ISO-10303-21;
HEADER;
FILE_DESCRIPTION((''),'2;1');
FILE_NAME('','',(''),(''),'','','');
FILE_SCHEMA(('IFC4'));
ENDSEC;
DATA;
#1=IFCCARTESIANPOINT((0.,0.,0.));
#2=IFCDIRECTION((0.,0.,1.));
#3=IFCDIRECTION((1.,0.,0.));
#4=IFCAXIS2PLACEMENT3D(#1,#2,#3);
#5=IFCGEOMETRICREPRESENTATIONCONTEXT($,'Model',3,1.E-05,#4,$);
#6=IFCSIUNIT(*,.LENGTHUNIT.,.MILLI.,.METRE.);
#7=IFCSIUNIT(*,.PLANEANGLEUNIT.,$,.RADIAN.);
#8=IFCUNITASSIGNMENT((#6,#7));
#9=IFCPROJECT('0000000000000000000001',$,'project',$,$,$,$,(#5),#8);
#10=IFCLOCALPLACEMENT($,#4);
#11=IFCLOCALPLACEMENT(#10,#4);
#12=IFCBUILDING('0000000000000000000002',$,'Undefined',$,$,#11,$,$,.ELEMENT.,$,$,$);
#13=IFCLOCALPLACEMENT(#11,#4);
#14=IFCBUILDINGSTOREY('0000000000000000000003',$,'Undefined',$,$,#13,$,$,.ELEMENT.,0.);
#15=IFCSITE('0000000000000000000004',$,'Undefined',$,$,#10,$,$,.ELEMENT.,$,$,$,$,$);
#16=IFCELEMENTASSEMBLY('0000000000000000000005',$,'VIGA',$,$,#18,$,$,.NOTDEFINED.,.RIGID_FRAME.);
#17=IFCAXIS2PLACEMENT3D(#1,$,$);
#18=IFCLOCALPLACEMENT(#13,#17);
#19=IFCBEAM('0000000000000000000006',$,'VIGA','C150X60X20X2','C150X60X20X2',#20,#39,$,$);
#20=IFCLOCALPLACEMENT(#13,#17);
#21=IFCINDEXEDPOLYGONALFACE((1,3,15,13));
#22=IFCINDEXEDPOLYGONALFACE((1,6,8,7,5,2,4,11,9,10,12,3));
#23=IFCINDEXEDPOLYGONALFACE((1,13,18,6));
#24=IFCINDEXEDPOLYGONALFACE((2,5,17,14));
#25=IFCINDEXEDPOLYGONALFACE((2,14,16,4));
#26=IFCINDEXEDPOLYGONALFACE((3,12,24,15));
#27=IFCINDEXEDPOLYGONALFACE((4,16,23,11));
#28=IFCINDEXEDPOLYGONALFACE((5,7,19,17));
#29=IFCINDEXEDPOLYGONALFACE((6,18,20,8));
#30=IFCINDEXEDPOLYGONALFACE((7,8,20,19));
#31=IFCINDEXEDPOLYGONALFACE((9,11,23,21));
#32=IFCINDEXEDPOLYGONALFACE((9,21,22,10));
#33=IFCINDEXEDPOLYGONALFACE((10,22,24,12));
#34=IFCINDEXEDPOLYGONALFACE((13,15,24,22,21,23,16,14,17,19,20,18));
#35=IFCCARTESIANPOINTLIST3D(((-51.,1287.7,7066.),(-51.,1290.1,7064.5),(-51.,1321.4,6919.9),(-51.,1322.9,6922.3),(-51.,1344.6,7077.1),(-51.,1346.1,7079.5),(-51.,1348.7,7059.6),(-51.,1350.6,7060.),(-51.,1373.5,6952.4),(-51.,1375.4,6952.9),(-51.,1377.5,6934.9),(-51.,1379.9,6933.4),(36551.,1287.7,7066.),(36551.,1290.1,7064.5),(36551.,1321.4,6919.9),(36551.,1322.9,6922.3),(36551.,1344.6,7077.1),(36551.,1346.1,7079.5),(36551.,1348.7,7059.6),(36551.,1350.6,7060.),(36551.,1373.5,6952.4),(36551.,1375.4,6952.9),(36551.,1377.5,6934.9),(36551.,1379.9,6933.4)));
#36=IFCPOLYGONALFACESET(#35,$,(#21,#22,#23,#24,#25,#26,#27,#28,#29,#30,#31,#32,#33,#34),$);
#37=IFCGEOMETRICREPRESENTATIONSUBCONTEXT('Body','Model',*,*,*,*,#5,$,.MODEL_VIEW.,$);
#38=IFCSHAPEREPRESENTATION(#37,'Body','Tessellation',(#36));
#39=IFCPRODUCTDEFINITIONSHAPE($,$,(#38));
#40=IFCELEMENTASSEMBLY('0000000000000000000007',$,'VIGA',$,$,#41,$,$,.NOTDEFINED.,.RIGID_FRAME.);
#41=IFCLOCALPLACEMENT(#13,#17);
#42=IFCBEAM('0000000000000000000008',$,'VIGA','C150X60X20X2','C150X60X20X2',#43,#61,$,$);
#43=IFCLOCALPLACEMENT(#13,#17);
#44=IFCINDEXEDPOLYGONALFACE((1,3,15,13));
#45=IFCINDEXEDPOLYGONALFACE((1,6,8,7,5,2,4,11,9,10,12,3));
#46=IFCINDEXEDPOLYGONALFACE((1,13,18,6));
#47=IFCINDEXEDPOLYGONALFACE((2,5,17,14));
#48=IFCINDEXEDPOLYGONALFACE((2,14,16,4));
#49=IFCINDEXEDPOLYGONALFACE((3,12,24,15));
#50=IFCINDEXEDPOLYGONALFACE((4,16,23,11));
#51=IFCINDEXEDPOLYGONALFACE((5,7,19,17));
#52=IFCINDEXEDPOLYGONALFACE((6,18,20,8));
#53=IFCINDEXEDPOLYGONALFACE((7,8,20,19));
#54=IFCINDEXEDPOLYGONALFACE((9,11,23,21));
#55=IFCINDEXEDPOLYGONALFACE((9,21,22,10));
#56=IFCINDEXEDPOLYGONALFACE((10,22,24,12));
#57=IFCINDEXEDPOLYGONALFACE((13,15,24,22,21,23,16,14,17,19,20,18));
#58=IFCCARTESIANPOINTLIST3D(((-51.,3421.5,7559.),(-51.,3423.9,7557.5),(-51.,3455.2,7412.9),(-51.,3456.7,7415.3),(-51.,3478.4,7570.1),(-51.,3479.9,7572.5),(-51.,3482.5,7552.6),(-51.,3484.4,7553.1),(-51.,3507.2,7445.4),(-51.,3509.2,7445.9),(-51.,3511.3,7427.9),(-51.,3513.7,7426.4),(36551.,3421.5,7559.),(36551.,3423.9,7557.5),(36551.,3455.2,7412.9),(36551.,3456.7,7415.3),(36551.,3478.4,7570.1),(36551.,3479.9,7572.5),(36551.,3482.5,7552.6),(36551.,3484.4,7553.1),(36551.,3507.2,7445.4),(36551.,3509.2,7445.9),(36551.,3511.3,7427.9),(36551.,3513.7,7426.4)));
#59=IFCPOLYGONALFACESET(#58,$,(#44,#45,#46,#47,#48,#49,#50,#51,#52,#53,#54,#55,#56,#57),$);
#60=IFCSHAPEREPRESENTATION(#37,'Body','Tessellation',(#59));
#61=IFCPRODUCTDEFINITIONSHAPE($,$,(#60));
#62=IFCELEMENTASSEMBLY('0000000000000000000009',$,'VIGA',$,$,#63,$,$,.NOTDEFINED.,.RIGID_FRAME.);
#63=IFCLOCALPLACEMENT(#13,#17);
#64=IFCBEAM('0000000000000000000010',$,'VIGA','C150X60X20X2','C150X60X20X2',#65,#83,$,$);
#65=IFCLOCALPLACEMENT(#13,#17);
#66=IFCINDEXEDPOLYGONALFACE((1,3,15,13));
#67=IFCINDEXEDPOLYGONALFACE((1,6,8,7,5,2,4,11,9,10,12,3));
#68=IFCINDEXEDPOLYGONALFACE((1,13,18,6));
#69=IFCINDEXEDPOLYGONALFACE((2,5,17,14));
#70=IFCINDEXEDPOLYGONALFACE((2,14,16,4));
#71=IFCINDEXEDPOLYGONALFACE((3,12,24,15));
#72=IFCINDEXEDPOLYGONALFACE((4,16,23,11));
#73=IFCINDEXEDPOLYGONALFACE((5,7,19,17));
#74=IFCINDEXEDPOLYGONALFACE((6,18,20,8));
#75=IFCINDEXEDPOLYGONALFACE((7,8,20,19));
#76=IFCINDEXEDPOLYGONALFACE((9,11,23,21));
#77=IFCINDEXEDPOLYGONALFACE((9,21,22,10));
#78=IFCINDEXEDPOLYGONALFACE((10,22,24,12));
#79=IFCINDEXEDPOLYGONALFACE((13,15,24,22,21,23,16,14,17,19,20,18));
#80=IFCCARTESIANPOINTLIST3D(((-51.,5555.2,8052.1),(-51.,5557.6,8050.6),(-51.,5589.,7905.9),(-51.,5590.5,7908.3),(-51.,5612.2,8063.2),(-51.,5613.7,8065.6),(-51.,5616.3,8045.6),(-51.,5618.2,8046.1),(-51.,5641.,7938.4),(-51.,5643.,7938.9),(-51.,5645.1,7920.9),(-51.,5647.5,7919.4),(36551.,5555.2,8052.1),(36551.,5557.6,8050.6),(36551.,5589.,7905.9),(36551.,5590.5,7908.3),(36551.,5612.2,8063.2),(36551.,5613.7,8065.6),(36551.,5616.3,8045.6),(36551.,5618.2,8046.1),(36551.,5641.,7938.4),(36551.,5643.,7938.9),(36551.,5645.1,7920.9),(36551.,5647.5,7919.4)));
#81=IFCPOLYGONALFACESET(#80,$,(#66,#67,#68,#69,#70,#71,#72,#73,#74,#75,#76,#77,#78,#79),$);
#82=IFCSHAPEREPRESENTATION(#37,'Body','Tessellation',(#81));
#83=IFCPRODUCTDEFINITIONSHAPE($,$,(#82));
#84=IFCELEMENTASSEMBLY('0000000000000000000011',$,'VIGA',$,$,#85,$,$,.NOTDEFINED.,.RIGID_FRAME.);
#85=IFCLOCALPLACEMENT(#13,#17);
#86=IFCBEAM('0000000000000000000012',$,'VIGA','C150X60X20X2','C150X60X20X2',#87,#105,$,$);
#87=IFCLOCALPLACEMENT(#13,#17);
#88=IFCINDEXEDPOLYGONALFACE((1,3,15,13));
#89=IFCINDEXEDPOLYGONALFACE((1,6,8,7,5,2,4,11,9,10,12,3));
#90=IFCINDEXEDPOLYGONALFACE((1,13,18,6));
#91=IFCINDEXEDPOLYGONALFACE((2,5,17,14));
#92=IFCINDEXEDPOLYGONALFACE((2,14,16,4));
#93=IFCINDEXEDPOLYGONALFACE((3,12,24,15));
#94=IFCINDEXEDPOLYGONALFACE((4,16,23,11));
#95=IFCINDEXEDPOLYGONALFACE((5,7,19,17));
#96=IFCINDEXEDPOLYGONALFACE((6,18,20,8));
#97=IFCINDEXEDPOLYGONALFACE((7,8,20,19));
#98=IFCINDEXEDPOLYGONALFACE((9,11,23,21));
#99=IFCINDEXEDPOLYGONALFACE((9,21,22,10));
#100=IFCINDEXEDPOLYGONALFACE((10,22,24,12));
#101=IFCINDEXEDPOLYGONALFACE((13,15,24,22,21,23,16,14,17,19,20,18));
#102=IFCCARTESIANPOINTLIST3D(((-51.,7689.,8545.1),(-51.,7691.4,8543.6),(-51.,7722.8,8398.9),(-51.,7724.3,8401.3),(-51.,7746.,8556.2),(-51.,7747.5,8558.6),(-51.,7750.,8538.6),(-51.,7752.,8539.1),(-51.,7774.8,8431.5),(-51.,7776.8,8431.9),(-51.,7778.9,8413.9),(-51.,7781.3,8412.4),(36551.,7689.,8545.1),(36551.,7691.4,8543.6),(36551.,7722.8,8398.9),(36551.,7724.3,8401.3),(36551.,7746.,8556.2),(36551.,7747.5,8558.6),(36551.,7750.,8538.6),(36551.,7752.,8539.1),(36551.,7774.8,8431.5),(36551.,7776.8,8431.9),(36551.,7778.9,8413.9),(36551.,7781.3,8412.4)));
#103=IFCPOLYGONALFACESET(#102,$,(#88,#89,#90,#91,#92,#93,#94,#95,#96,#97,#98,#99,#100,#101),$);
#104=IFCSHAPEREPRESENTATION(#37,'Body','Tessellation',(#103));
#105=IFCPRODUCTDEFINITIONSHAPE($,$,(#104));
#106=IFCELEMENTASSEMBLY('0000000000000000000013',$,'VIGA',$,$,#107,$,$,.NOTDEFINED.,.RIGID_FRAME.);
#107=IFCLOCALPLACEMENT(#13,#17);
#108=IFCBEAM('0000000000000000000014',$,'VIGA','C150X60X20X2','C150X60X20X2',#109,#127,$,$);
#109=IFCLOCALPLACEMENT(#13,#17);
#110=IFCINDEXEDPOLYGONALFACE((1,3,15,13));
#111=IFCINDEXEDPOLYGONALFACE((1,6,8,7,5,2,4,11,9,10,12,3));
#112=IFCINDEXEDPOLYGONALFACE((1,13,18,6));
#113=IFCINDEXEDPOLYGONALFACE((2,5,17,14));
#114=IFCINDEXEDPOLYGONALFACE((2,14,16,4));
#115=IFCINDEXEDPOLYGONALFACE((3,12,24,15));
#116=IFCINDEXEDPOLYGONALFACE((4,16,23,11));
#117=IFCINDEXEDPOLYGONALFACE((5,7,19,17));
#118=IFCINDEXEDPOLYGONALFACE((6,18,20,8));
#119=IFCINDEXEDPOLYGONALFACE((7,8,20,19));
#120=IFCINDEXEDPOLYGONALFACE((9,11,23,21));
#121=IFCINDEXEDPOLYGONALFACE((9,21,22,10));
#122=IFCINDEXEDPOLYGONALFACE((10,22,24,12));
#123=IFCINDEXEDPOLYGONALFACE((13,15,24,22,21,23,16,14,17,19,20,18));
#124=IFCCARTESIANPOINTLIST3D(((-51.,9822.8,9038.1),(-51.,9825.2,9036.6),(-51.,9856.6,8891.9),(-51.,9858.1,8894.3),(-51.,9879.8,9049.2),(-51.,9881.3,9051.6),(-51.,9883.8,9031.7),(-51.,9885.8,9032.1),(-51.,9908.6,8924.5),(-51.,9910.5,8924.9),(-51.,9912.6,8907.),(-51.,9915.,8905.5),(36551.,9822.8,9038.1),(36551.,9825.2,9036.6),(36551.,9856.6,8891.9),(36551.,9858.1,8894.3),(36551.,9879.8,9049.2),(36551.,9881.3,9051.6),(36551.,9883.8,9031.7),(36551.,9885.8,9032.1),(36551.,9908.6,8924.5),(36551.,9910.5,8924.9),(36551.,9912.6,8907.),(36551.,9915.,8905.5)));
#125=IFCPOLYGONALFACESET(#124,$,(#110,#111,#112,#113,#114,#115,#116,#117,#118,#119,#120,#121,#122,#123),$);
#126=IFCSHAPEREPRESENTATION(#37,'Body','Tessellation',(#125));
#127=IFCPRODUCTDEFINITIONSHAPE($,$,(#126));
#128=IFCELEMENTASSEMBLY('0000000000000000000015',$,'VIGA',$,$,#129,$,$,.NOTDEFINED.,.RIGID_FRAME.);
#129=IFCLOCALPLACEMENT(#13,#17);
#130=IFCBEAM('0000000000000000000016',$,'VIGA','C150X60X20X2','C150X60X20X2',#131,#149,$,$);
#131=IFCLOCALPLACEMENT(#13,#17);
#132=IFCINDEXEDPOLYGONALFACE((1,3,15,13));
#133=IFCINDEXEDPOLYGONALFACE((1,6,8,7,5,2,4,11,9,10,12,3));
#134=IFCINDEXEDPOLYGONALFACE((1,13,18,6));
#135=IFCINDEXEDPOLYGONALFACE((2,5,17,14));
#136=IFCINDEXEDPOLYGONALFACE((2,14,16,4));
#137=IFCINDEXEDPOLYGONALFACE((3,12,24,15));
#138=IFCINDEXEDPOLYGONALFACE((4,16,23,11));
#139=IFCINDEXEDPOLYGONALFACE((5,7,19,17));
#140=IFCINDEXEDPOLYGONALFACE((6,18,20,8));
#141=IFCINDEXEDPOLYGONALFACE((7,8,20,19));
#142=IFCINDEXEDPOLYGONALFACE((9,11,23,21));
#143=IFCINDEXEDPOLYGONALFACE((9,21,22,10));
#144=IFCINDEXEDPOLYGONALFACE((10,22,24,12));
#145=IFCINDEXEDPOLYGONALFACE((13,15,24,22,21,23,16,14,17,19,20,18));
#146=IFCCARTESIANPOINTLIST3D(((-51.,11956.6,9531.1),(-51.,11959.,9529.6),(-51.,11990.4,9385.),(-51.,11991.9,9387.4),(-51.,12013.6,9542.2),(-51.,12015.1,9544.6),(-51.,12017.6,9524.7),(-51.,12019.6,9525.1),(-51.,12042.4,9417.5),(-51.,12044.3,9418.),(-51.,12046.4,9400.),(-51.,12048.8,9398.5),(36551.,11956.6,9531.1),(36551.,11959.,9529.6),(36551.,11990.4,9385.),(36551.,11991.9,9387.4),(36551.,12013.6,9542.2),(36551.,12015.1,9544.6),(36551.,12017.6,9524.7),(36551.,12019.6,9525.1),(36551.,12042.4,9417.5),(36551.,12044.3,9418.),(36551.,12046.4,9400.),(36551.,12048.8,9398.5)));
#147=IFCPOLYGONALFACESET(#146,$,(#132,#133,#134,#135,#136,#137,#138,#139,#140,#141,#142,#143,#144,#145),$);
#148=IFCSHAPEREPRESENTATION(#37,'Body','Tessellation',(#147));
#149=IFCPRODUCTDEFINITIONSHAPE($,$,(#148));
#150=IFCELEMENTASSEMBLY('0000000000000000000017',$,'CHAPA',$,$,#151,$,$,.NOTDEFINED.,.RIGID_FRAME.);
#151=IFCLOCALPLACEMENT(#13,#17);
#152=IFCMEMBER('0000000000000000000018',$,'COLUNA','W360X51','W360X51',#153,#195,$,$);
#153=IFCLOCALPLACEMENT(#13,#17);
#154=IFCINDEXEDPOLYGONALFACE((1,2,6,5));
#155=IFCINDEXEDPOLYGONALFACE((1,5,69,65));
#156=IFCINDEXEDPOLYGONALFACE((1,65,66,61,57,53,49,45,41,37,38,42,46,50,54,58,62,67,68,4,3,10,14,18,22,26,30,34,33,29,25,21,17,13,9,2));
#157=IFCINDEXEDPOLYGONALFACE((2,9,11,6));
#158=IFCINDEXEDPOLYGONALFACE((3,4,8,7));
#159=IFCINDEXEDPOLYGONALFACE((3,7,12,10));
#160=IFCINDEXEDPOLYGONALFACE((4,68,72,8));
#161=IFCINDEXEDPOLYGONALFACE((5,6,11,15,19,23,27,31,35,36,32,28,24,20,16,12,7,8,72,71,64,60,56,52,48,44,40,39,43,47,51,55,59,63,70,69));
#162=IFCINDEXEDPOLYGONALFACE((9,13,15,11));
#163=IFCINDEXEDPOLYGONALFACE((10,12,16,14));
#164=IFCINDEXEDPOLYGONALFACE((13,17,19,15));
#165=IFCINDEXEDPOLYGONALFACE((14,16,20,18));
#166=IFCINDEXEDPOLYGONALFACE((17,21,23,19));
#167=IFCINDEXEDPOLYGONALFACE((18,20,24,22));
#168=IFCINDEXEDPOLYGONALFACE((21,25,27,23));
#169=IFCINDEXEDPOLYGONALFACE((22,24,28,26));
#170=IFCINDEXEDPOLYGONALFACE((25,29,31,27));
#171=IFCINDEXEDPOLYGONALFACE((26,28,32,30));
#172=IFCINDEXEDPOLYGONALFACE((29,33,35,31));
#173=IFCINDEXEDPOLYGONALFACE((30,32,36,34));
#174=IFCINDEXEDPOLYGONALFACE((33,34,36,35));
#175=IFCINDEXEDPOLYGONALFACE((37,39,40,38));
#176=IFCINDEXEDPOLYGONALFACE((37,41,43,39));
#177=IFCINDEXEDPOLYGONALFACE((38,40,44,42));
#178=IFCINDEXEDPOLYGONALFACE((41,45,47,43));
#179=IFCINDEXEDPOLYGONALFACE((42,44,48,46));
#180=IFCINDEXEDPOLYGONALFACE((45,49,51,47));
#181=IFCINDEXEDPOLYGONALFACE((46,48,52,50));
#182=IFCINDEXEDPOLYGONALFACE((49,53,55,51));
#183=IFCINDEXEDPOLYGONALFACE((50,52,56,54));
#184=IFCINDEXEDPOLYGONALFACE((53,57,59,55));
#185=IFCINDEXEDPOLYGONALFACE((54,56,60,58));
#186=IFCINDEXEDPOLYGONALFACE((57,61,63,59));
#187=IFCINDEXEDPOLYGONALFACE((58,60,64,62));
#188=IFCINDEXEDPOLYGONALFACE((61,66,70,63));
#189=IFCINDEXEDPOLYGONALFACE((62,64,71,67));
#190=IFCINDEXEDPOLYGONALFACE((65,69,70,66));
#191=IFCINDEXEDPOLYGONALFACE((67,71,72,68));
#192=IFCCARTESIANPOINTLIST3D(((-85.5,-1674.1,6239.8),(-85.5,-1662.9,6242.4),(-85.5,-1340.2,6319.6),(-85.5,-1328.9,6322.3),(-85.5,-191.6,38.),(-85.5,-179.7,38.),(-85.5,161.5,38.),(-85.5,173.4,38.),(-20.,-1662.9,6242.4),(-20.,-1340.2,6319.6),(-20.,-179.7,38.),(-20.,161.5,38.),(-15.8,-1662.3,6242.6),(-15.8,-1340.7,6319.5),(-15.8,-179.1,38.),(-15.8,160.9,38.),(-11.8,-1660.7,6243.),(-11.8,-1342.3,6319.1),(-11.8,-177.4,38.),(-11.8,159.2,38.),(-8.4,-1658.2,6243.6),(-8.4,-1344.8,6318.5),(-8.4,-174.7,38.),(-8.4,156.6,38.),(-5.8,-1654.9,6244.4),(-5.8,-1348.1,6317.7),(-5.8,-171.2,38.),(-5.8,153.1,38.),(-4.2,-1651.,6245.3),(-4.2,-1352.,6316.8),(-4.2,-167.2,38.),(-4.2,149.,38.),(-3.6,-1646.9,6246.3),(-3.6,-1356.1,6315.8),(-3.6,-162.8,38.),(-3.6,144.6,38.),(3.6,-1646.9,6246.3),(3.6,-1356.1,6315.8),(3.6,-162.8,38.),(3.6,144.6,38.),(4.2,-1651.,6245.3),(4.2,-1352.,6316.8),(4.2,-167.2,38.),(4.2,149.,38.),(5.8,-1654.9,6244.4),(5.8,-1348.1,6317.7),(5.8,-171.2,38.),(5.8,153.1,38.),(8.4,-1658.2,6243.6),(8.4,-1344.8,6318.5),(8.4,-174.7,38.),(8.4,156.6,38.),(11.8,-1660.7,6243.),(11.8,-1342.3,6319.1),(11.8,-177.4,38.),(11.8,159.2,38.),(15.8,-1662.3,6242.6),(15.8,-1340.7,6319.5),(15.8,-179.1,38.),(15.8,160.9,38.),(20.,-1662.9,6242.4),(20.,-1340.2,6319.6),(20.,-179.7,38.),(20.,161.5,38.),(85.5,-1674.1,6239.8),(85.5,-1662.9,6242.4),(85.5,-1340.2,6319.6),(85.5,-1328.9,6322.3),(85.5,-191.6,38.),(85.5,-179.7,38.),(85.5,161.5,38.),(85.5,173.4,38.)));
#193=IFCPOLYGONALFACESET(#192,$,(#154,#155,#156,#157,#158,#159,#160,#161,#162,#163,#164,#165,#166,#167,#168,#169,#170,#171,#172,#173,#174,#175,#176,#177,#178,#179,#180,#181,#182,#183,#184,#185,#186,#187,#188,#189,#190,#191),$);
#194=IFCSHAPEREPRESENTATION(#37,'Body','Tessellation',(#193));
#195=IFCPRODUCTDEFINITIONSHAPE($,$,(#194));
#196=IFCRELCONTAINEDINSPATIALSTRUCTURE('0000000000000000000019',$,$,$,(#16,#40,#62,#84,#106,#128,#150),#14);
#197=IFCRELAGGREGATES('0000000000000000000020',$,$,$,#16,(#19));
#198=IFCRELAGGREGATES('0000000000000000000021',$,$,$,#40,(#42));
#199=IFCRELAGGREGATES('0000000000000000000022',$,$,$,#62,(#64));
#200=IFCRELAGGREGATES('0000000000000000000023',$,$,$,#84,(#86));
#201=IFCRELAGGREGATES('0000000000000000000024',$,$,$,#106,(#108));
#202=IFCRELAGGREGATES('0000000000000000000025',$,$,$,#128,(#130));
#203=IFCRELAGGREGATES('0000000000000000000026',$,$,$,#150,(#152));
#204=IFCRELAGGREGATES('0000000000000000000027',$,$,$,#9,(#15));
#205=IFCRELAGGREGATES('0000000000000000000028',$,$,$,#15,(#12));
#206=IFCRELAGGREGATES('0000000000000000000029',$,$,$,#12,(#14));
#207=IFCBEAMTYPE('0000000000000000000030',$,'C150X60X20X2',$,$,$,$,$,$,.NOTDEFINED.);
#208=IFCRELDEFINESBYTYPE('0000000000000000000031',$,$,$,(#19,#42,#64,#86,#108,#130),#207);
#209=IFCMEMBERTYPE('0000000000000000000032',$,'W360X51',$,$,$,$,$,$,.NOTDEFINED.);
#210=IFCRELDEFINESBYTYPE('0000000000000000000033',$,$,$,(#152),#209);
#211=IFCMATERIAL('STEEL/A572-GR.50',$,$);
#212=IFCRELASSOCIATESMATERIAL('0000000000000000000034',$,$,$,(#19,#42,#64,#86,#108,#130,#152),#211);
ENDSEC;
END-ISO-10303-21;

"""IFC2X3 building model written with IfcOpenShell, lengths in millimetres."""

from ifc_helpers import new_model, si_unit, frame, origin_with_axes, origin_2d_with_axis, place, context, subcontext, project, spatial, i_section, c_section, extrude, clip, halfspace, material, type_object, element, aggregate, save


model = new_model("IFC2X3")

# Units and contexts
model_context = context("Model", 3, precision=1e-05, world=origin_with_axes())
body_context = subcontext(model_context, "Body", "Model", "MODEL_VIEW")
ifc_project = project(units=[si_unit("LENGTHUNIT", "METRE", prefix="MILLI"), si_unit("PLANEANGLEUNIT", "RADIAN")], contexts=[model_context])

# Site, building, storey
site_placement = place(None, origin_with_axes())
site = spatial("IfcSite", under=ifc_project, at=site_placement, Name="Undefined", CompositionType="ELEMENT")
building_placement = place(site_placement, origin_with_axes())
building = spatial("IfcBuilding", under=site, at=building_placement, Name="Undefined", CompositionType="ELEMENT")
storey_placement = place(building_placement, origin_with_axes())
storey = spatial("IfcBuildingStorey", under=building, at=storey_placement, Name="Undefined", CompositionType="ELEMENT", Elevation=0.0)

# Element assemblies, beams
assembly_1_placement = place(storey_placement, origin_with_axes())
assembly_1 = element("IfcElementAssembly", 1, at=assembly_1_placement, inside=storey, Name="VIGA", AssemblyPlace="NOTDEFINED", PredefinedType="RIGID_FRAME")
ifc_material_1 = material(Name="STEEL/A572-GR.50")
beam_type = type_object("IfcBeamType", Name="C150X60X20X2", PredefinedType="NOTDEFINED")
beam_1_placement = place(assembly_1_placement, frame((-51.0, 1333.8, 6999.7), z_axis=(0.0, 0.225124, -0.97433), x_axis=(1.0, 0.0, 0.0)))
beam_1 = element("IfcBeam", 2, at=beam_1_placement, type_object=beam_type, material=ifc_material_1, Name="VIGA", Description="C150X60X20X2", ObjectType="C150X60X20X2", context=body_context, shape_type="SweptSolid", body=[
    extrude(c_section(Depth=150.0, Width=60.0, WallThickness=2.0, Girth=20.0, at=origin_2d_with_axis()), frame((36602.0, 0.0, 0.0), z_axis=(-1.0, 0.0, 0.0), x_axis=(0.0, -1.0, 0.0)), (0.0, 0.0, 1.0), 36602.0),
])
assembly_2_placement = place(storey_placement, origin_with_axes())
assembly_2 = element("IfcElementAssembly", 3, at=assembly_2_placement, inside=storey, Name="VIGA", AssemblyPlace="NOTDEFINED", PredefinedType="RIGID_FRAME")
beam_2_placement = place(assembly_2_placement, frame((-51.0, 3467.6, 7492.7), z_axis=(0.0, 0.225124, -0.97433), x_axis=(1.0, 0.0, 0.0)))
beam_2 = element("IfcBeam", 4, at=beam_2_placement, type_object=beam_type, material=ifc_material_1, Name="VIGA", Description="C150X60X20X2", ObjectType="C150X60X20X2", context=body_context, shape_type="SweptSolid", body=[
    extrude(c_section(Depth=150.0, Width=60.0, WallThickness=2.0, Girth=20.0, at=origin_2d_with_axis()), frame((36602.0, 0.0, 0.0), z_axis=(-1.0, 0.0, 0.0), x_axis=(0.0, -1.0, 0.0)), (0.0, 0.0, 1.0), 36602.0),
])
assembly_3_placement = place(storey_placement, origin_with_axes())
assembly_3 = element("IfcElementAssembly", 5, at=assembly_3_placement, inside=storey, Name="VIGA", AssemblyPlace="NOTDEFINED", PredefinedType="RIGID_FRAME")
beam_3_placement = place(assembly_3_placement, frame((-51.0, 5601.4, 7985.7), z_axis=(0.0, 0.225124, -0.97433), x_axis=(1.0, 0.0, 0.0)))
beam_3 = element("IfcBeam", 6, at=beam_3_placement, type_object=beam_type, material=ifc_material_1, Name="VIGA", Description="C150X60X20X2", ObjectType="C150X60X20X2", context=body_context, shape_type="SweptSolid", body=[
    extrude(c_section(Depth=150.0, Width=60.0, WallThickness=2.0, Girth=20.0, at=origin_2d_with_axis()), frame((36602.0, 0.0, 0.0), z_axis=(-1.0, 0.0, 0.0), x_axis=(0.0, -1.0, 0.0)), (0.0, 0.0, 1.0), 36602.0),
])
assembly_4_placement = place(storey_placement, origin_with_axes())
assembly_4 = element("IfcElementAssembly", 7, at=assembly_4_placement, inside=storey, Name="VIGA", AssemblyPlace="NOTDEFINED", PredefinedType="RIGID_FRAME")
beam_4_placement = place(assembly_4_placement, frame((-51.0, 7735.1, 8478.8), z_axis=(0.0, 0.225124, -0.97433), x_axis=(1.0, 0.0, 0.0)))
beam_4 = element("IfcBeam", 8, at=beam_4_placement, type_object=beam_type, material=ifc_material_1, Name="VIGA", Description="C150X60X20X2", ObjectType="C150X60X20X2", context=body_context, shape_type="SweptSolid", body=[
    extrude(c_section(Depth=150.0, Width=60.0, WallThickness=2.0, Girth=20.0, at=origin_2d_with_axis()), frame((36602.0, 0.0, 0.0), z_axis=(-1.0, 0.0, 0.0), x_axis=(0.0, -1.0, 0.0)), (0.0, 0.0, 1.0), 36602.0),
])
assembly_5_placement = place(storey_placement, origin_with_axes())
assembly_5 = element("IfcElementAssembly", 9, at=assembly_5_placement, inside=storey, Name="VIGA", AssemblyPlace="NOTDEFINED", PredefinedType="RIGID_FRAME")
beam_5_placement = place(assembly_5_placement, frame((-51.0, 9868.9, 8971.8), z_axis=(0.0, 0.225124, -0.97433), x_axis=(1.0, 0.0, 0.0)))
beam_5 = element("IfcBeam", 10, at=beam_5_placement, type_object=beam_type, material=ifc_material_1, Name="VIGA", Description="C150X60X20X2", ObjectType="C150X60X20X2", context=body_context, shape_type="SweptSolid", body=[
    extrude(c_section(Depth=150.0, Width=60.0, WallThickness=2.0, Girth=20.0, at=origin_2d_with_axis()), frame((36602.0, 0.0, 0.0), z_axis=(-1.0, 0.0, 0.0), x_axis=(0.0, -1.0, 0.0)), (0.0, 0.0, 1.0), 36602.0),
])
assembly_6_placement = place(storey_placement, origin_with_axes())
assembly_6 = element("IfcElementAssembly", 11, at=assembly_6_placement, inside=storey, Name="VIGA", AssemblyPlace="NOTDEFINED", PredefinedType="RIGID_FRAME")
beam_6_placement = place(assembly_6_placement, frame((-51.0, 12002.7, 9464.8), z_axis=(0.0, 0.225124, -0.97433), x_axis=(1.0, 0.0, 0.0)))
beam_6 = element("IfcBeam", 12, at=beam_6_placement, type_object=beam_type, material=ifc_material_1, Name="VIGA", Description="C150X60X20X2", ObjectType="C150X60X20X2", context=body_context, shape_type="SweptSolid", body=[
    extrude(c_section(Depth=150.0, Width=60.0, WallThickness=2.0, Girth=20.0, at=origin_2d_with_axis()), frame((36602.0, 0.0, 0.0), z_axis=(-1.0, 0.0, 0.0), x_axis=(0.0, -1.0, 0.0)), (0.0, 0.0, 1.0), 36602.0),
])

# Element assembly, member
assembly_7_placement = place(storey_placement, origin_with_axes())
assembly_7 = element("IfcElementAssembly", 13, at=assembly_7_placement, inside=storey, Name="CHAPA", AssemblyPlace="NOTDEFINED", PredefinedType="RIGID_FRAME")
member_type = type_object("IfcMemberType", Name="W360X51", PredefinedType="NOTDEFINED")
member_placement = place(assembly_7_placement, frame((0.0, 23.3, -97.3), z_axis=(0.0, -0.972595, -0.232504), x_axis=(0.0, -0.232504, 0.972595)))
member = element("IfcMember", 14, at=member_placement, type_object=member_type, material=ifc_material_1, Name="COLUNA", Description="W360X51", ObjectType="W360X51", context=body_context, shape_type="Clipping", body=[
    clip(clip(extrude(i_section(OverallWidth=171.0, OverallDepth=355.0, WebThickness=7.2, FlangeThickness=11.6, FilletRadius=16.4, at=origin_2d_with_axis()), frame((6558.0, 0.0, 0.0), z_axis=(-1.0, 0.0, 0.0), x_axis=(0.0, -1.0, 0.0)), (0.0, 0.0, 1.0), 6542.9), halfspace(frame((94.5, 85.5, -186.3), z_axis=(-0.972595, 0.0, 0.232504), x_axis=(0.232504, 0.0, 0.972595)), False)), halfspace(frame((96.6, 0.0, -177.5), z_axis=(0.972595, 0.0, -0.232504), x_axis=(0.0, -1.0, 0.0)), True)),
])

aggregate(assembly_1, [beam_1])
aggregate(assembly_2, [beam_2])
aggregate(assembly_3, [beam_3])
aggregate(assembly_4, [beam_4])
aggregate(assembly_5, [beam_5])
aggregate(assembly_6, [beam_6])
aggregate(assembly_7, [member])

save(model, "model.ifc")
